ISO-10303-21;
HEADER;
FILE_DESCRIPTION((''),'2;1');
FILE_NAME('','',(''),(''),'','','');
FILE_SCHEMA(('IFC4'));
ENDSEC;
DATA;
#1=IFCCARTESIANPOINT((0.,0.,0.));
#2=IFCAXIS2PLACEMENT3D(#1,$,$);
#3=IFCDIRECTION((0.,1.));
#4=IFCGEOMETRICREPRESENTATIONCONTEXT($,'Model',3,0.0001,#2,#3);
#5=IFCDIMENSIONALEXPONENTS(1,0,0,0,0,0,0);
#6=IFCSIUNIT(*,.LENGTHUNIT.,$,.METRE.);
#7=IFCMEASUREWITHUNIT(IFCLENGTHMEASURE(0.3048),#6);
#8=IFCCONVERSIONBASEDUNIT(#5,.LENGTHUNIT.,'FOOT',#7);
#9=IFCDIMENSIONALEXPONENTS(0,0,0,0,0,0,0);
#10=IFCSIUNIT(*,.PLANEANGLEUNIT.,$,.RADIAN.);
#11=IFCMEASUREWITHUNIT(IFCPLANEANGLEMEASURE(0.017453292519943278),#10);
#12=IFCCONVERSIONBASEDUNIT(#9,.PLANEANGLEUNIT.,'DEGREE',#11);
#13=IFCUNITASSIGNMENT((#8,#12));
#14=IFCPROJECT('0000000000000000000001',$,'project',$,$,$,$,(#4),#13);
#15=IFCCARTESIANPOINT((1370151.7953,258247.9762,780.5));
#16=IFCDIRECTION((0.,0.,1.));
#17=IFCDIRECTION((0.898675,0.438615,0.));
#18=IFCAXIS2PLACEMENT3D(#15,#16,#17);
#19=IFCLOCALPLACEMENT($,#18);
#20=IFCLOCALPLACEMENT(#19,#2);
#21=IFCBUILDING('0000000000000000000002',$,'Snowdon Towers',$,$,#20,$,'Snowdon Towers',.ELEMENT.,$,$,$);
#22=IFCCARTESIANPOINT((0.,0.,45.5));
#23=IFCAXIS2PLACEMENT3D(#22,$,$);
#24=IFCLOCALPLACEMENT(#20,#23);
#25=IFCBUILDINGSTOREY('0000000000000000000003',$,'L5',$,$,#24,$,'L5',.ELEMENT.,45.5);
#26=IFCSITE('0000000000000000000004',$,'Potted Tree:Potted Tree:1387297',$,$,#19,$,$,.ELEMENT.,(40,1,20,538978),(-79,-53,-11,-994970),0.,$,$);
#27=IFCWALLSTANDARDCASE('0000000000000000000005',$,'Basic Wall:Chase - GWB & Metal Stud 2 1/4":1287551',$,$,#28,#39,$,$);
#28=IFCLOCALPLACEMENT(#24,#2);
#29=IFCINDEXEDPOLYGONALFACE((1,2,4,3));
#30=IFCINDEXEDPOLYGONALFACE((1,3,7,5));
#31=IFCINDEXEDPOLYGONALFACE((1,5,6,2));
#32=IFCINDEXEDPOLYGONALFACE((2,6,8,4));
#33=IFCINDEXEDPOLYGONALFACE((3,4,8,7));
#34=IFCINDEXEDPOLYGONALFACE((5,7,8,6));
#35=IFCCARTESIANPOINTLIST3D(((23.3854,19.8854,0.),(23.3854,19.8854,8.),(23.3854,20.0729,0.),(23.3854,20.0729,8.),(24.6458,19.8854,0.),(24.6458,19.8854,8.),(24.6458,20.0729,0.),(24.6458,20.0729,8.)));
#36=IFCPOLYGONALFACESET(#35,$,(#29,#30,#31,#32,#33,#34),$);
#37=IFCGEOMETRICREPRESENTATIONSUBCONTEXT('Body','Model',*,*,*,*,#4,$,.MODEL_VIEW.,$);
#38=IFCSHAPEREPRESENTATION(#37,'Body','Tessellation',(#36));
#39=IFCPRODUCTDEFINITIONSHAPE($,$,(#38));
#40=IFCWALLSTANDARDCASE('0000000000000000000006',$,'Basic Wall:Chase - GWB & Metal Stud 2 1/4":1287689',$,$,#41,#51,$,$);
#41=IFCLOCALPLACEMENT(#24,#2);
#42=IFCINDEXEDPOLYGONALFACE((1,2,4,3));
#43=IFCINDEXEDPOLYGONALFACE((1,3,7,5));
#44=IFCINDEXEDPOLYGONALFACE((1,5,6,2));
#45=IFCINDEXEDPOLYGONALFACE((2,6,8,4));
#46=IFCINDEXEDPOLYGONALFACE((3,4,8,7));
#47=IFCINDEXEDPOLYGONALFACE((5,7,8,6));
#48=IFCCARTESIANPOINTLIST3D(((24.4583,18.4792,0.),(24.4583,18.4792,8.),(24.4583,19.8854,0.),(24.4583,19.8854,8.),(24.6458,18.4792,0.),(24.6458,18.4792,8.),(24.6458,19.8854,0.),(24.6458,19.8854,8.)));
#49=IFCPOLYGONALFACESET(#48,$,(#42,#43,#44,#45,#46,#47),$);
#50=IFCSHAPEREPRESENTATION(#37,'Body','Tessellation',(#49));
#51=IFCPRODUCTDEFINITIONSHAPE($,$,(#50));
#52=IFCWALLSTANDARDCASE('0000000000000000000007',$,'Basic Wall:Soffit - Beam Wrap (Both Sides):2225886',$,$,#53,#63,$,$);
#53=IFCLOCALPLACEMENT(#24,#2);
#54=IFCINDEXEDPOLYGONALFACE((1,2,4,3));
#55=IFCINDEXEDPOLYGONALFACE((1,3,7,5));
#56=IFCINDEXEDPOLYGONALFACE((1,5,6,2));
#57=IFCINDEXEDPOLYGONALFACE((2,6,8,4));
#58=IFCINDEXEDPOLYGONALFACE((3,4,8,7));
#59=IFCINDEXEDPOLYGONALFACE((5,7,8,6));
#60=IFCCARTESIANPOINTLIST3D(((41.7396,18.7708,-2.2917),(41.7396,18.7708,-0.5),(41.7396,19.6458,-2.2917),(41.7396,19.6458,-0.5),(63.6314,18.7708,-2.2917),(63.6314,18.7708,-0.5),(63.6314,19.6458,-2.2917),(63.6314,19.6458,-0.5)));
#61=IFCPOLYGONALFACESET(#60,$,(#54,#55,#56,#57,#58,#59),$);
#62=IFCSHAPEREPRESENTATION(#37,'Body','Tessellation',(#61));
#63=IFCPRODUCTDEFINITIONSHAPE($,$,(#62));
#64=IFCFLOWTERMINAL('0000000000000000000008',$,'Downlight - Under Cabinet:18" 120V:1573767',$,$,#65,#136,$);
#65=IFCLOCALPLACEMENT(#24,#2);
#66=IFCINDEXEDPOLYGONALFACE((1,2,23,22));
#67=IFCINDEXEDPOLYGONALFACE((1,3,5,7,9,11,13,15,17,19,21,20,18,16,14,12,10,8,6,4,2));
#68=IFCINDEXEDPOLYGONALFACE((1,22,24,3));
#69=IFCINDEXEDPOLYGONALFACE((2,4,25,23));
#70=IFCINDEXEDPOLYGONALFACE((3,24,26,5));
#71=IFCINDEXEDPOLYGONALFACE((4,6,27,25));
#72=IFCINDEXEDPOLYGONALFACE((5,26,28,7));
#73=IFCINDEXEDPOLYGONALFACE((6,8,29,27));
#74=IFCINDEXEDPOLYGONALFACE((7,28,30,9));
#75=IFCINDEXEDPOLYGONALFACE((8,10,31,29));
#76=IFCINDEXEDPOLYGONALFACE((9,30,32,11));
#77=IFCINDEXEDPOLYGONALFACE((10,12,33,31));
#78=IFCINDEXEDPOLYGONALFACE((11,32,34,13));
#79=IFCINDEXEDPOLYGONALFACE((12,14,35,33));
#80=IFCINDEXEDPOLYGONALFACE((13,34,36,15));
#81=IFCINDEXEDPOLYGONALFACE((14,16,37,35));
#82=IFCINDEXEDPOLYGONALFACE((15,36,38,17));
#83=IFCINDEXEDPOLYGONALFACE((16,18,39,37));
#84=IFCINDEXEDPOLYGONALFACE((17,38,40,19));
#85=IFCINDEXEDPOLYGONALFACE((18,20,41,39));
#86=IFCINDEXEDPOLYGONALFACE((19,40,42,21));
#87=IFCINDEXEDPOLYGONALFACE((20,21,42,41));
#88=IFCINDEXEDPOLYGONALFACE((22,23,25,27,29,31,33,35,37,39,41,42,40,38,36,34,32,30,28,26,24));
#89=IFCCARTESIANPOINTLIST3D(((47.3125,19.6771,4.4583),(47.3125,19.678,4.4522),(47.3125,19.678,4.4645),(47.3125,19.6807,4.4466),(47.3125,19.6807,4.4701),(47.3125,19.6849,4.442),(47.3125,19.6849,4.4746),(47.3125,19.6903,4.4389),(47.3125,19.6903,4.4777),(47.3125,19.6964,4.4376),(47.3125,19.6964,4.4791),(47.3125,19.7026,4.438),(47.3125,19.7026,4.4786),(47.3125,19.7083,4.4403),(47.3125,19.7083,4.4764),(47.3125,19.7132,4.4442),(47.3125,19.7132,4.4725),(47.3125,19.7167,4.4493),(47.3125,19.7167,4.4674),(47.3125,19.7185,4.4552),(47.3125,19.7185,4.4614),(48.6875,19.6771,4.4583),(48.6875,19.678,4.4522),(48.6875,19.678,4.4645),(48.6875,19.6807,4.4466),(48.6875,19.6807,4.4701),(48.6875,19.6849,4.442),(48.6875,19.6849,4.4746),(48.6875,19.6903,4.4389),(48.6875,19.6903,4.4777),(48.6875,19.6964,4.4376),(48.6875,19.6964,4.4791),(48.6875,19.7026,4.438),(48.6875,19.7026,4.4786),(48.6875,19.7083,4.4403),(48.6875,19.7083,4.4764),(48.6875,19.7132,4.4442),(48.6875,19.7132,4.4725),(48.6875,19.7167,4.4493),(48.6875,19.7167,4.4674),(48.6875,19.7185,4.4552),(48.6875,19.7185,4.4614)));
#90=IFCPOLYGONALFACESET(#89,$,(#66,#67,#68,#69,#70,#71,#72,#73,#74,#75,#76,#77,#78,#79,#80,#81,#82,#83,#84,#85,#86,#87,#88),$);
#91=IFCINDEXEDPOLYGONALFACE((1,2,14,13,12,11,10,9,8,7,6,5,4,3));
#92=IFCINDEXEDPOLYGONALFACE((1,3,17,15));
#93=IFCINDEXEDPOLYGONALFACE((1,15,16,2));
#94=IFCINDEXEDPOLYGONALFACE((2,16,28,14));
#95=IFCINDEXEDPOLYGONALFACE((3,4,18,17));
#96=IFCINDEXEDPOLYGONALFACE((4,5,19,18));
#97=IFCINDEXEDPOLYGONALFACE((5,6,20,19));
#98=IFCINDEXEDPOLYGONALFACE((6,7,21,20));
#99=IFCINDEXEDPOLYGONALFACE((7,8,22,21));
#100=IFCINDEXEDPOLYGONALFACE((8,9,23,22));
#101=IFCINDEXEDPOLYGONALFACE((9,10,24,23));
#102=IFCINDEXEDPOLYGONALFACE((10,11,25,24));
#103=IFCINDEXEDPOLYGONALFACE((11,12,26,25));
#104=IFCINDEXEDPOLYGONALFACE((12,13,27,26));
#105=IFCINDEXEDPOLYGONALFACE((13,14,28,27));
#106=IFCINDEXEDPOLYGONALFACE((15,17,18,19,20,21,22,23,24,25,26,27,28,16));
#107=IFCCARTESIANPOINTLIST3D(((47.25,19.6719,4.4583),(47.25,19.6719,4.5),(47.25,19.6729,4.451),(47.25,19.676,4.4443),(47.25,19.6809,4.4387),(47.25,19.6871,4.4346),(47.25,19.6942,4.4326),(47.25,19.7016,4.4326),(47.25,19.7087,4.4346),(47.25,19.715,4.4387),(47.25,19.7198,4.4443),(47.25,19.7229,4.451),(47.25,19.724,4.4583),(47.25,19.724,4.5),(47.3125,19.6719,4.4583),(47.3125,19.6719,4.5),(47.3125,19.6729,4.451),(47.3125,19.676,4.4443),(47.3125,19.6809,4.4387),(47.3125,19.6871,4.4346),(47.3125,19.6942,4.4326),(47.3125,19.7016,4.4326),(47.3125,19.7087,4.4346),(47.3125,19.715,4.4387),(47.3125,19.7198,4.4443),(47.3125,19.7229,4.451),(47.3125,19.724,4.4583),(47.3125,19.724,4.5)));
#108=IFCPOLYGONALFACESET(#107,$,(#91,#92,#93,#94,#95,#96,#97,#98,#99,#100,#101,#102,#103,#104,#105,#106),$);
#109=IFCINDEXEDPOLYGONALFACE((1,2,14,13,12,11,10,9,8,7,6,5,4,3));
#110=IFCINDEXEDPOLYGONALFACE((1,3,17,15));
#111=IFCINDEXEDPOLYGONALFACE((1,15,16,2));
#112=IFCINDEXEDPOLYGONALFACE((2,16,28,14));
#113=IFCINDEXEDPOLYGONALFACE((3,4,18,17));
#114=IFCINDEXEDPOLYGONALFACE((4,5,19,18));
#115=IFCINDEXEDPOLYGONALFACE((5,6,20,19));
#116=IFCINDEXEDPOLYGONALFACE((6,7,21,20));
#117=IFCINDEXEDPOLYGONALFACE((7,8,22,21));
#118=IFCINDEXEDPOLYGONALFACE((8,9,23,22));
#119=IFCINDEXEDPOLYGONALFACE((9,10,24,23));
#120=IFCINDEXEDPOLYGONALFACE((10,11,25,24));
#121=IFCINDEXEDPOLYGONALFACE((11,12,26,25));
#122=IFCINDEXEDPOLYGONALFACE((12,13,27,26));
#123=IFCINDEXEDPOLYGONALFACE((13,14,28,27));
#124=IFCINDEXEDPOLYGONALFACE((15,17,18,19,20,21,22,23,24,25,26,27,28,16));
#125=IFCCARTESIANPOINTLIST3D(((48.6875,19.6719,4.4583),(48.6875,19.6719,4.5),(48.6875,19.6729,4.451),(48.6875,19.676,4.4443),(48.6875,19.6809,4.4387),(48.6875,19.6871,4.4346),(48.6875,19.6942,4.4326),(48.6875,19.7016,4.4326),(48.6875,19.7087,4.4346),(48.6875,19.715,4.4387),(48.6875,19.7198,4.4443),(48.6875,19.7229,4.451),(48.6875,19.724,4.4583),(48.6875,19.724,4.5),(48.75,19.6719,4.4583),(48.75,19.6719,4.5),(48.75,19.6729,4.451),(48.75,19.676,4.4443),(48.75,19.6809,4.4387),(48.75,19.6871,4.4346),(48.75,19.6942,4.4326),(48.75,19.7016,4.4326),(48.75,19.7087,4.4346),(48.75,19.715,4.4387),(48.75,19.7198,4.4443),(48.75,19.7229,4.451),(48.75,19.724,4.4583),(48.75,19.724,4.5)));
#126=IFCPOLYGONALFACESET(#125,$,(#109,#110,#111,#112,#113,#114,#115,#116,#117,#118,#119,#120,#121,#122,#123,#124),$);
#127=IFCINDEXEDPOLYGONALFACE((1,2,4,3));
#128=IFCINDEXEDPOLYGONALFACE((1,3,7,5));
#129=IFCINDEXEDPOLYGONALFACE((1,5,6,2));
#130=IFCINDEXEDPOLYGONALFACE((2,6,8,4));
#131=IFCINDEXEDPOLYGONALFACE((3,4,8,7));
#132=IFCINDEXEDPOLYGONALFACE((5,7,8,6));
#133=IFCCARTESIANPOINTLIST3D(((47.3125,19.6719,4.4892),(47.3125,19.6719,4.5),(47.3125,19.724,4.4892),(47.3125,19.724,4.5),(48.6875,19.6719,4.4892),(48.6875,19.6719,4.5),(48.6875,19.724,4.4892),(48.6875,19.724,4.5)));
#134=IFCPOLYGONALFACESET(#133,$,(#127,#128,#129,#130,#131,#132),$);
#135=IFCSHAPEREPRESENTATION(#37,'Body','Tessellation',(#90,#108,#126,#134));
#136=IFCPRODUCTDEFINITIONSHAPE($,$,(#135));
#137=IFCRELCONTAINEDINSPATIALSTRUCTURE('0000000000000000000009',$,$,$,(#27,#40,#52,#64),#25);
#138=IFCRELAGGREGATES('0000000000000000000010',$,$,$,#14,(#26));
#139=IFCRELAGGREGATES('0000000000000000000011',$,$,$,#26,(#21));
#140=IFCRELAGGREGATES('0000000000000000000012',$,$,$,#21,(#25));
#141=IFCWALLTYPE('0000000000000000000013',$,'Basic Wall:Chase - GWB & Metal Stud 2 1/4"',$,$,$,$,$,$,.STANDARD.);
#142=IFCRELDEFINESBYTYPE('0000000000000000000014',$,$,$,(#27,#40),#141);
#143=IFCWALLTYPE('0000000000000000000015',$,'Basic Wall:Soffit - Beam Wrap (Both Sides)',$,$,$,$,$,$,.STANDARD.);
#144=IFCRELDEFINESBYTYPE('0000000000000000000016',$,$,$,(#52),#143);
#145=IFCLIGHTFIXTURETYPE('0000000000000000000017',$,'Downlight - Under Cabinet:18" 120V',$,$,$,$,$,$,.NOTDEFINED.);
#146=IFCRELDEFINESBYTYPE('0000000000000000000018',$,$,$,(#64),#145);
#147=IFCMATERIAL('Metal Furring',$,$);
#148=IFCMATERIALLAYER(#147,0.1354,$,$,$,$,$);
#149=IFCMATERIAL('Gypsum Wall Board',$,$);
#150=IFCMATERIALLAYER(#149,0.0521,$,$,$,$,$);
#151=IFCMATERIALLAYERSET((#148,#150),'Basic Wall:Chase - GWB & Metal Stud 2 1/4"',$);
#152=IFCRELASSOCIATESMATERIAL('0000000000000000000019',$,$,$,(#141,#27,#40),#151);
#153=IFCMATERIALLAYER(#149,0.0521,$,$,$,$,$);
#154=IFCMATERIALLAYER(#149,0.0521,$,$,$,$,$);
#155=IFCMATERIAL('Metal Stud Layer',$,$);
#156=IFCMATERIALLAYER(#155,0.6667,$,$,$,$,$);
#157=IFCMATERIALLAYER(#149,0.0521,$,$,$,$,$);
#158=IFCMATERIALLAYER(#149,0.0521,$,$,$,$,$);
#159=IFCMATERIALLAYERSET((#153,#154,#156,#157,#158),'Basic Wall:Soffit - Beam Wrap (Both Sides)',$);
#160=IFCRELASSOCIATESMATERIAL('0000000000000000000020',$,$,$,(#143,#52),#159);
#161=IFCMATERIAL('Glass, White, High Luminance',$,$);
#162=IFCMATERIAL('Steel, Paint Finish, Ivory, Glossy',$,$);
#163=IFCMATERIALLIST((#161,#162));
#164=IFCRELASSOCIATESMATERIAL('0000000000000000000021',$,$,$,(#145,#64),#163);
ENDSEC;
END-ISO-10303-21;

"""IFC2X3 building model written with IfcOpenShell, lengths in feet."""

from ifc_helpers import new_model, entity, si_unit, converted_unit, direction, frame, frame_2d, origin, origin_2d_with_axis, place, context, subcontext, project, spatial, polyline, circle_curve, parameter, trimmed, segment, composite_curve, rectangle, circle, outline, extrude, source, transform, mapped, material, material_list, layer, layer_set, layer_usage, type_object, type_shapes, element, save


model = new_model("IFC2X3")

# Units and contexts
model_context = context("Model", 3, precision=0.0001, world=origin(), true_north=direction((0.0, 1.0)))
body_context = subcontext(model_context, "Body", "Model", "MODEL_VIEW")
ifc_project = project(units=[converted_unit("LENGTHUNIT", "FOOT", entity("IfcLengthMeasure", 0.3048), si_unit("LENGTHUNIT", "METRE"), dimensions=[1, 0, 0, 0, 0, 0, 0]), converted_unit("PLANEANGLEUNIT", "DEGREE", entity("IfcPlaneAngleMeasure", 0.017453292519943278), si_unit("PLANEANGLEUNIT", "RADIAN"), dimensions=[0, 0, 0, 0, 0, 0, 0])], contexts=[model_context])

# Site, building, storey
site_placement = place(None, frame((1370151.7953, 258247.9762, 780.5), z_axis=(0.0, 0.0, 1.0), x_axis=(0.898675, 0.438615, 0.0)))
site = spatial("IfcSite", under=ifc_project, at=site_placement, Name="Potted Tree:Potted Tree:1387297", CompositionType="ELEMENT", RefLatitude=(40, 1, 20, 538978), RefLongitude=(-79, -53, -11, -994970), RefElevation=0.0)
building_placement = place(site_placement, origin())
building = spatial("IfcBuilding", under=site, at=building_placement, Name="Snowdon Towers", LongName="Snowdon Towers", CompositionType="ELEMENT")
storey_placement = place(building_placement, frame((0.0, 0.0, 45.5)))
storey = spatial("IfcBuildingStorey", under=building, at=storey_placement, Name="L5", LongName="L5", CompositionType="ELEMENT", Elevation=45.5)

# Walls
ifc_material_1 = material(Name="Metal Furring")
ifc_material_2 = material(Name="Gypsum Wall Board")
ifc_material_3 = material(Name="Metal Stud Layer")
ifc_layer_1 = layer(ifc_material_1, 0.1354)
ifc_layer_2 = layer(ifc_material_2, 0.0521)
ifc_layer_set_1 = layer_set([ifc_layer_1, ifc_layer_2], Name="Basic Wall:Chase - GWB & Metal Stud 2 1/4\"")
wall_type_1 = type_object("IfcWallType", Name="Basic Wall:Chase - GWB & Metal Stud 2 1/4\"", PredefinedType="STANDARD", material=ifc_layer_set_1)
ifc_layer_usage_1 = layer_usage(ifc_layer_set_1, "AXIS2", "POSITIVE", -0.0938)
wall_1_placement = place(storey_placement, frame((23.3854, 19.9792, 0.0)))
element("IfcWallStandardCase", 1, at=wall_1_placement, inside=storey, type_object=wall_type_1, material=ifc_layer_usage_1, Name="Basic Wall:Chase - GWB & Metal Stud 2 1/4\":1287551", context=body_context, shape_type="SweptSolid", body=[
    extrude(rectangle(XDim=1.2604, YDim=0.1875, at=frame_2d((0.6302, 0.0), x_axis=(-1.0, 0.0))), origin(), (0.0, 0.0, 1.0), 8.0),
])
ifc_layer_usage_2 = layer_usage(ifc_layer_set_1, "AXIS2", "POSITIVE", -0.0938)
wall_2_placement = place(storey_placement, frame((24.5521, 19.8854, 0.0), z_axis=(0.0, 0.0, 1.0), x_axis=(0.0, -1.0, 0.0)))
element("IfcWallStandardCase", 2, at=wall_2_placement, inside=storey, type_object=wall_type_1, material=ifc_layer_usage_2, Name="Basic Wall:Chase - GWB & Metal Stud 2 1/4\":1287689", context=body_context, shape_type="SweptSolid", body=[
    extrude(rectangle(XDim=1.4063, YDim=0.1875, at=frame_2d((0.7031, 0.0), x_axis=(-1.0, 0.0))), origin(), (0.0, 0.0, 1.0), 8.0),
])
ifc_layer_3 = layer(ifc_material_2, 0.0521)
ifc_layer_4 = layer(ifc_material_2, 0.0521)
ifc_layer_5 = layer(ifc_material_3, 0.6667)
ifc_layer_6 = layer(ifc_material_2, 0.0521)
ifc_layer_7 = layer(ifc_material_2, 0.0521)
ifc_layer_set_2 = layer_set([ifc_layer_3, ifc_layer_4, ifc_layer_5, ifc_layer_6, ifc_layer_7], Name="Basic Wall:Soffit - Beam Wrap (Both Sides)")
ifc_layer_usage_3 = layer_usage(ifc_layer_set_2, "AXIS2", "NEGATIVE", 0.4375)
wall_type_2 = type_object("IfcWallType", Name="Basic Wall:Soffit - Beam Wrap (Both Sides)", PredefinedType="STANDARD", material=ifc_layer_set_2)
wall_3_placement = place(storey_placement, frame((41.7396, 19.2083, -2.2917)))
element("IfcWallStandardCase", 3, at=wall_3_placement, inside=storey, type_object=wall_type_2, material=ifc_layer_usage_3, Name="Basic Wall:Soffit - Beam Wrap (Both Sides):2225886", context=body_context, shape_type="SweptSolid", body=[
    extrude(rectangle(XDim=21.8918, YDim=0.875, at=frame_2d((10.9459, 0.0), x_axis=(-1.0, 0.0))), origin(), (0.0, 0.0, 1.0), 1.7917),
])

# Flow terminal
ifc_material_4 = material(Name="Glass, White, High Luminance")
ifc_material_5 = material(Name="Steel, Paint Finish, Ivory, Glossy")
ifc_material_list_1 = material_list([ifc_material_4, ifc_material_5])
light_fixture_type_1 = type_object("IfcLightFixtureType", Name="Downlight - Under Cabinet:18\" 120V", PredefinedType="NOTDEFINED", material=ifc_material_list_1)
shared_shape_1 = source(origin(), body_context, "Body", "SweptSolid", [
    extrude(circle(Radius=0.0208, at=origin_2d_with_axis()), frame((-0.6875, 0.0, 4.4583), z_axis=(1.0, 0.0, 0.0), x_axis=(0.0, 1.0, 0.0)), (0.0, 0.0, 1.0), 1.375),
    extrude(outline(composite_curve([segment(polyline([(-0.0208, -0.026), (0.0208, -0.026)]), True, "CONTINUOUS"), segment(trimmed(circle_curve(frame_2d((0.0208, 0.0), x_axis=(0.0, 1.0)), 0.026), [parameter(180.0)], [parameter(0.0)], True, "PARAMETER"), True, "CONTINUOUS"), segment(polyline([(0.0208, 0.026), (-0.0208, 0.026)]), True, "CONTINUOUS"), segment(polyline([(-0.0208, 0.026), (-0.0208, -0.026)]), True, "CONTINUOUS")], self_intersect=False)), frame((0.6875, 0.0, 4.4792), z_axis=(1.0, 0.0, 0.0), x_axis=(0.0, 0.0, -1.0)), (0.0, 0.0, 1.0), 0.0625),
    extrude(outline(composite_curve([segment(polyline([(-0.026, -0.0208), (0.026, -0.0208)]), True, "CONTINUOUS"), segment(polyline([(0.026, -0.0208), (0.026, 0.0208)]), True, "CONTINUOUS"), segment(trimmed(circle_curve(frame_2d((0.0, 0.0208), x_axis=(0.0, -1.0)), 0.026), [parameter(90.0)], [parameter(270.0)], True, "PARAMETER"), True, "CONTINUOUS"), segment(polyline([(-0.026, 0.0208), (-0.026, -0.0208)]), True, "CONTINUOUS")], self_intersect=False)), frame((-0.75, 0.0, 4.4792), z_axis=(1.0, 0.0, 0.0), x_axis=(0.0, -1.0, 0.0)), (0.0, 0.0, 1.0), 0.0625),
    extrude(rectangle(XDim=1.375, YDim=0.0521, at=origin_2d_with_axis()), frame((0.0, 0.0, 4.4892), z_axis=(0.0, 0.0, 1.0), x_axis=(-1.0, 0.0, 0.0)), (0.0, 0.0, 1.0), 0.0108),
])
type_shapes(light_fixture_type_1, [shared_shape_1])
flow_terminal_1_placement = place(storey_placement, frame((48.0, 19.6979, 0.0), z_axis=(0.0, 0.0, 1.0), x_axis=(-1.0, 0.0, 0.0)))
element("IfcFlowTerminal", 4, at=flow_terminal_1_placement, inside=storey, type_object=light_fixture_type_1, material=ifc_material_list_1, Name="Downlight - Under Cabinet:18\" 120V:1573767", context=body_context, shape_type="MappedRepresentation", body=[
    mapped(shared_shape_1, transform((0.0, 0.0, 0.0), scale=1.0)),
])

save(model, "model.ifc")
